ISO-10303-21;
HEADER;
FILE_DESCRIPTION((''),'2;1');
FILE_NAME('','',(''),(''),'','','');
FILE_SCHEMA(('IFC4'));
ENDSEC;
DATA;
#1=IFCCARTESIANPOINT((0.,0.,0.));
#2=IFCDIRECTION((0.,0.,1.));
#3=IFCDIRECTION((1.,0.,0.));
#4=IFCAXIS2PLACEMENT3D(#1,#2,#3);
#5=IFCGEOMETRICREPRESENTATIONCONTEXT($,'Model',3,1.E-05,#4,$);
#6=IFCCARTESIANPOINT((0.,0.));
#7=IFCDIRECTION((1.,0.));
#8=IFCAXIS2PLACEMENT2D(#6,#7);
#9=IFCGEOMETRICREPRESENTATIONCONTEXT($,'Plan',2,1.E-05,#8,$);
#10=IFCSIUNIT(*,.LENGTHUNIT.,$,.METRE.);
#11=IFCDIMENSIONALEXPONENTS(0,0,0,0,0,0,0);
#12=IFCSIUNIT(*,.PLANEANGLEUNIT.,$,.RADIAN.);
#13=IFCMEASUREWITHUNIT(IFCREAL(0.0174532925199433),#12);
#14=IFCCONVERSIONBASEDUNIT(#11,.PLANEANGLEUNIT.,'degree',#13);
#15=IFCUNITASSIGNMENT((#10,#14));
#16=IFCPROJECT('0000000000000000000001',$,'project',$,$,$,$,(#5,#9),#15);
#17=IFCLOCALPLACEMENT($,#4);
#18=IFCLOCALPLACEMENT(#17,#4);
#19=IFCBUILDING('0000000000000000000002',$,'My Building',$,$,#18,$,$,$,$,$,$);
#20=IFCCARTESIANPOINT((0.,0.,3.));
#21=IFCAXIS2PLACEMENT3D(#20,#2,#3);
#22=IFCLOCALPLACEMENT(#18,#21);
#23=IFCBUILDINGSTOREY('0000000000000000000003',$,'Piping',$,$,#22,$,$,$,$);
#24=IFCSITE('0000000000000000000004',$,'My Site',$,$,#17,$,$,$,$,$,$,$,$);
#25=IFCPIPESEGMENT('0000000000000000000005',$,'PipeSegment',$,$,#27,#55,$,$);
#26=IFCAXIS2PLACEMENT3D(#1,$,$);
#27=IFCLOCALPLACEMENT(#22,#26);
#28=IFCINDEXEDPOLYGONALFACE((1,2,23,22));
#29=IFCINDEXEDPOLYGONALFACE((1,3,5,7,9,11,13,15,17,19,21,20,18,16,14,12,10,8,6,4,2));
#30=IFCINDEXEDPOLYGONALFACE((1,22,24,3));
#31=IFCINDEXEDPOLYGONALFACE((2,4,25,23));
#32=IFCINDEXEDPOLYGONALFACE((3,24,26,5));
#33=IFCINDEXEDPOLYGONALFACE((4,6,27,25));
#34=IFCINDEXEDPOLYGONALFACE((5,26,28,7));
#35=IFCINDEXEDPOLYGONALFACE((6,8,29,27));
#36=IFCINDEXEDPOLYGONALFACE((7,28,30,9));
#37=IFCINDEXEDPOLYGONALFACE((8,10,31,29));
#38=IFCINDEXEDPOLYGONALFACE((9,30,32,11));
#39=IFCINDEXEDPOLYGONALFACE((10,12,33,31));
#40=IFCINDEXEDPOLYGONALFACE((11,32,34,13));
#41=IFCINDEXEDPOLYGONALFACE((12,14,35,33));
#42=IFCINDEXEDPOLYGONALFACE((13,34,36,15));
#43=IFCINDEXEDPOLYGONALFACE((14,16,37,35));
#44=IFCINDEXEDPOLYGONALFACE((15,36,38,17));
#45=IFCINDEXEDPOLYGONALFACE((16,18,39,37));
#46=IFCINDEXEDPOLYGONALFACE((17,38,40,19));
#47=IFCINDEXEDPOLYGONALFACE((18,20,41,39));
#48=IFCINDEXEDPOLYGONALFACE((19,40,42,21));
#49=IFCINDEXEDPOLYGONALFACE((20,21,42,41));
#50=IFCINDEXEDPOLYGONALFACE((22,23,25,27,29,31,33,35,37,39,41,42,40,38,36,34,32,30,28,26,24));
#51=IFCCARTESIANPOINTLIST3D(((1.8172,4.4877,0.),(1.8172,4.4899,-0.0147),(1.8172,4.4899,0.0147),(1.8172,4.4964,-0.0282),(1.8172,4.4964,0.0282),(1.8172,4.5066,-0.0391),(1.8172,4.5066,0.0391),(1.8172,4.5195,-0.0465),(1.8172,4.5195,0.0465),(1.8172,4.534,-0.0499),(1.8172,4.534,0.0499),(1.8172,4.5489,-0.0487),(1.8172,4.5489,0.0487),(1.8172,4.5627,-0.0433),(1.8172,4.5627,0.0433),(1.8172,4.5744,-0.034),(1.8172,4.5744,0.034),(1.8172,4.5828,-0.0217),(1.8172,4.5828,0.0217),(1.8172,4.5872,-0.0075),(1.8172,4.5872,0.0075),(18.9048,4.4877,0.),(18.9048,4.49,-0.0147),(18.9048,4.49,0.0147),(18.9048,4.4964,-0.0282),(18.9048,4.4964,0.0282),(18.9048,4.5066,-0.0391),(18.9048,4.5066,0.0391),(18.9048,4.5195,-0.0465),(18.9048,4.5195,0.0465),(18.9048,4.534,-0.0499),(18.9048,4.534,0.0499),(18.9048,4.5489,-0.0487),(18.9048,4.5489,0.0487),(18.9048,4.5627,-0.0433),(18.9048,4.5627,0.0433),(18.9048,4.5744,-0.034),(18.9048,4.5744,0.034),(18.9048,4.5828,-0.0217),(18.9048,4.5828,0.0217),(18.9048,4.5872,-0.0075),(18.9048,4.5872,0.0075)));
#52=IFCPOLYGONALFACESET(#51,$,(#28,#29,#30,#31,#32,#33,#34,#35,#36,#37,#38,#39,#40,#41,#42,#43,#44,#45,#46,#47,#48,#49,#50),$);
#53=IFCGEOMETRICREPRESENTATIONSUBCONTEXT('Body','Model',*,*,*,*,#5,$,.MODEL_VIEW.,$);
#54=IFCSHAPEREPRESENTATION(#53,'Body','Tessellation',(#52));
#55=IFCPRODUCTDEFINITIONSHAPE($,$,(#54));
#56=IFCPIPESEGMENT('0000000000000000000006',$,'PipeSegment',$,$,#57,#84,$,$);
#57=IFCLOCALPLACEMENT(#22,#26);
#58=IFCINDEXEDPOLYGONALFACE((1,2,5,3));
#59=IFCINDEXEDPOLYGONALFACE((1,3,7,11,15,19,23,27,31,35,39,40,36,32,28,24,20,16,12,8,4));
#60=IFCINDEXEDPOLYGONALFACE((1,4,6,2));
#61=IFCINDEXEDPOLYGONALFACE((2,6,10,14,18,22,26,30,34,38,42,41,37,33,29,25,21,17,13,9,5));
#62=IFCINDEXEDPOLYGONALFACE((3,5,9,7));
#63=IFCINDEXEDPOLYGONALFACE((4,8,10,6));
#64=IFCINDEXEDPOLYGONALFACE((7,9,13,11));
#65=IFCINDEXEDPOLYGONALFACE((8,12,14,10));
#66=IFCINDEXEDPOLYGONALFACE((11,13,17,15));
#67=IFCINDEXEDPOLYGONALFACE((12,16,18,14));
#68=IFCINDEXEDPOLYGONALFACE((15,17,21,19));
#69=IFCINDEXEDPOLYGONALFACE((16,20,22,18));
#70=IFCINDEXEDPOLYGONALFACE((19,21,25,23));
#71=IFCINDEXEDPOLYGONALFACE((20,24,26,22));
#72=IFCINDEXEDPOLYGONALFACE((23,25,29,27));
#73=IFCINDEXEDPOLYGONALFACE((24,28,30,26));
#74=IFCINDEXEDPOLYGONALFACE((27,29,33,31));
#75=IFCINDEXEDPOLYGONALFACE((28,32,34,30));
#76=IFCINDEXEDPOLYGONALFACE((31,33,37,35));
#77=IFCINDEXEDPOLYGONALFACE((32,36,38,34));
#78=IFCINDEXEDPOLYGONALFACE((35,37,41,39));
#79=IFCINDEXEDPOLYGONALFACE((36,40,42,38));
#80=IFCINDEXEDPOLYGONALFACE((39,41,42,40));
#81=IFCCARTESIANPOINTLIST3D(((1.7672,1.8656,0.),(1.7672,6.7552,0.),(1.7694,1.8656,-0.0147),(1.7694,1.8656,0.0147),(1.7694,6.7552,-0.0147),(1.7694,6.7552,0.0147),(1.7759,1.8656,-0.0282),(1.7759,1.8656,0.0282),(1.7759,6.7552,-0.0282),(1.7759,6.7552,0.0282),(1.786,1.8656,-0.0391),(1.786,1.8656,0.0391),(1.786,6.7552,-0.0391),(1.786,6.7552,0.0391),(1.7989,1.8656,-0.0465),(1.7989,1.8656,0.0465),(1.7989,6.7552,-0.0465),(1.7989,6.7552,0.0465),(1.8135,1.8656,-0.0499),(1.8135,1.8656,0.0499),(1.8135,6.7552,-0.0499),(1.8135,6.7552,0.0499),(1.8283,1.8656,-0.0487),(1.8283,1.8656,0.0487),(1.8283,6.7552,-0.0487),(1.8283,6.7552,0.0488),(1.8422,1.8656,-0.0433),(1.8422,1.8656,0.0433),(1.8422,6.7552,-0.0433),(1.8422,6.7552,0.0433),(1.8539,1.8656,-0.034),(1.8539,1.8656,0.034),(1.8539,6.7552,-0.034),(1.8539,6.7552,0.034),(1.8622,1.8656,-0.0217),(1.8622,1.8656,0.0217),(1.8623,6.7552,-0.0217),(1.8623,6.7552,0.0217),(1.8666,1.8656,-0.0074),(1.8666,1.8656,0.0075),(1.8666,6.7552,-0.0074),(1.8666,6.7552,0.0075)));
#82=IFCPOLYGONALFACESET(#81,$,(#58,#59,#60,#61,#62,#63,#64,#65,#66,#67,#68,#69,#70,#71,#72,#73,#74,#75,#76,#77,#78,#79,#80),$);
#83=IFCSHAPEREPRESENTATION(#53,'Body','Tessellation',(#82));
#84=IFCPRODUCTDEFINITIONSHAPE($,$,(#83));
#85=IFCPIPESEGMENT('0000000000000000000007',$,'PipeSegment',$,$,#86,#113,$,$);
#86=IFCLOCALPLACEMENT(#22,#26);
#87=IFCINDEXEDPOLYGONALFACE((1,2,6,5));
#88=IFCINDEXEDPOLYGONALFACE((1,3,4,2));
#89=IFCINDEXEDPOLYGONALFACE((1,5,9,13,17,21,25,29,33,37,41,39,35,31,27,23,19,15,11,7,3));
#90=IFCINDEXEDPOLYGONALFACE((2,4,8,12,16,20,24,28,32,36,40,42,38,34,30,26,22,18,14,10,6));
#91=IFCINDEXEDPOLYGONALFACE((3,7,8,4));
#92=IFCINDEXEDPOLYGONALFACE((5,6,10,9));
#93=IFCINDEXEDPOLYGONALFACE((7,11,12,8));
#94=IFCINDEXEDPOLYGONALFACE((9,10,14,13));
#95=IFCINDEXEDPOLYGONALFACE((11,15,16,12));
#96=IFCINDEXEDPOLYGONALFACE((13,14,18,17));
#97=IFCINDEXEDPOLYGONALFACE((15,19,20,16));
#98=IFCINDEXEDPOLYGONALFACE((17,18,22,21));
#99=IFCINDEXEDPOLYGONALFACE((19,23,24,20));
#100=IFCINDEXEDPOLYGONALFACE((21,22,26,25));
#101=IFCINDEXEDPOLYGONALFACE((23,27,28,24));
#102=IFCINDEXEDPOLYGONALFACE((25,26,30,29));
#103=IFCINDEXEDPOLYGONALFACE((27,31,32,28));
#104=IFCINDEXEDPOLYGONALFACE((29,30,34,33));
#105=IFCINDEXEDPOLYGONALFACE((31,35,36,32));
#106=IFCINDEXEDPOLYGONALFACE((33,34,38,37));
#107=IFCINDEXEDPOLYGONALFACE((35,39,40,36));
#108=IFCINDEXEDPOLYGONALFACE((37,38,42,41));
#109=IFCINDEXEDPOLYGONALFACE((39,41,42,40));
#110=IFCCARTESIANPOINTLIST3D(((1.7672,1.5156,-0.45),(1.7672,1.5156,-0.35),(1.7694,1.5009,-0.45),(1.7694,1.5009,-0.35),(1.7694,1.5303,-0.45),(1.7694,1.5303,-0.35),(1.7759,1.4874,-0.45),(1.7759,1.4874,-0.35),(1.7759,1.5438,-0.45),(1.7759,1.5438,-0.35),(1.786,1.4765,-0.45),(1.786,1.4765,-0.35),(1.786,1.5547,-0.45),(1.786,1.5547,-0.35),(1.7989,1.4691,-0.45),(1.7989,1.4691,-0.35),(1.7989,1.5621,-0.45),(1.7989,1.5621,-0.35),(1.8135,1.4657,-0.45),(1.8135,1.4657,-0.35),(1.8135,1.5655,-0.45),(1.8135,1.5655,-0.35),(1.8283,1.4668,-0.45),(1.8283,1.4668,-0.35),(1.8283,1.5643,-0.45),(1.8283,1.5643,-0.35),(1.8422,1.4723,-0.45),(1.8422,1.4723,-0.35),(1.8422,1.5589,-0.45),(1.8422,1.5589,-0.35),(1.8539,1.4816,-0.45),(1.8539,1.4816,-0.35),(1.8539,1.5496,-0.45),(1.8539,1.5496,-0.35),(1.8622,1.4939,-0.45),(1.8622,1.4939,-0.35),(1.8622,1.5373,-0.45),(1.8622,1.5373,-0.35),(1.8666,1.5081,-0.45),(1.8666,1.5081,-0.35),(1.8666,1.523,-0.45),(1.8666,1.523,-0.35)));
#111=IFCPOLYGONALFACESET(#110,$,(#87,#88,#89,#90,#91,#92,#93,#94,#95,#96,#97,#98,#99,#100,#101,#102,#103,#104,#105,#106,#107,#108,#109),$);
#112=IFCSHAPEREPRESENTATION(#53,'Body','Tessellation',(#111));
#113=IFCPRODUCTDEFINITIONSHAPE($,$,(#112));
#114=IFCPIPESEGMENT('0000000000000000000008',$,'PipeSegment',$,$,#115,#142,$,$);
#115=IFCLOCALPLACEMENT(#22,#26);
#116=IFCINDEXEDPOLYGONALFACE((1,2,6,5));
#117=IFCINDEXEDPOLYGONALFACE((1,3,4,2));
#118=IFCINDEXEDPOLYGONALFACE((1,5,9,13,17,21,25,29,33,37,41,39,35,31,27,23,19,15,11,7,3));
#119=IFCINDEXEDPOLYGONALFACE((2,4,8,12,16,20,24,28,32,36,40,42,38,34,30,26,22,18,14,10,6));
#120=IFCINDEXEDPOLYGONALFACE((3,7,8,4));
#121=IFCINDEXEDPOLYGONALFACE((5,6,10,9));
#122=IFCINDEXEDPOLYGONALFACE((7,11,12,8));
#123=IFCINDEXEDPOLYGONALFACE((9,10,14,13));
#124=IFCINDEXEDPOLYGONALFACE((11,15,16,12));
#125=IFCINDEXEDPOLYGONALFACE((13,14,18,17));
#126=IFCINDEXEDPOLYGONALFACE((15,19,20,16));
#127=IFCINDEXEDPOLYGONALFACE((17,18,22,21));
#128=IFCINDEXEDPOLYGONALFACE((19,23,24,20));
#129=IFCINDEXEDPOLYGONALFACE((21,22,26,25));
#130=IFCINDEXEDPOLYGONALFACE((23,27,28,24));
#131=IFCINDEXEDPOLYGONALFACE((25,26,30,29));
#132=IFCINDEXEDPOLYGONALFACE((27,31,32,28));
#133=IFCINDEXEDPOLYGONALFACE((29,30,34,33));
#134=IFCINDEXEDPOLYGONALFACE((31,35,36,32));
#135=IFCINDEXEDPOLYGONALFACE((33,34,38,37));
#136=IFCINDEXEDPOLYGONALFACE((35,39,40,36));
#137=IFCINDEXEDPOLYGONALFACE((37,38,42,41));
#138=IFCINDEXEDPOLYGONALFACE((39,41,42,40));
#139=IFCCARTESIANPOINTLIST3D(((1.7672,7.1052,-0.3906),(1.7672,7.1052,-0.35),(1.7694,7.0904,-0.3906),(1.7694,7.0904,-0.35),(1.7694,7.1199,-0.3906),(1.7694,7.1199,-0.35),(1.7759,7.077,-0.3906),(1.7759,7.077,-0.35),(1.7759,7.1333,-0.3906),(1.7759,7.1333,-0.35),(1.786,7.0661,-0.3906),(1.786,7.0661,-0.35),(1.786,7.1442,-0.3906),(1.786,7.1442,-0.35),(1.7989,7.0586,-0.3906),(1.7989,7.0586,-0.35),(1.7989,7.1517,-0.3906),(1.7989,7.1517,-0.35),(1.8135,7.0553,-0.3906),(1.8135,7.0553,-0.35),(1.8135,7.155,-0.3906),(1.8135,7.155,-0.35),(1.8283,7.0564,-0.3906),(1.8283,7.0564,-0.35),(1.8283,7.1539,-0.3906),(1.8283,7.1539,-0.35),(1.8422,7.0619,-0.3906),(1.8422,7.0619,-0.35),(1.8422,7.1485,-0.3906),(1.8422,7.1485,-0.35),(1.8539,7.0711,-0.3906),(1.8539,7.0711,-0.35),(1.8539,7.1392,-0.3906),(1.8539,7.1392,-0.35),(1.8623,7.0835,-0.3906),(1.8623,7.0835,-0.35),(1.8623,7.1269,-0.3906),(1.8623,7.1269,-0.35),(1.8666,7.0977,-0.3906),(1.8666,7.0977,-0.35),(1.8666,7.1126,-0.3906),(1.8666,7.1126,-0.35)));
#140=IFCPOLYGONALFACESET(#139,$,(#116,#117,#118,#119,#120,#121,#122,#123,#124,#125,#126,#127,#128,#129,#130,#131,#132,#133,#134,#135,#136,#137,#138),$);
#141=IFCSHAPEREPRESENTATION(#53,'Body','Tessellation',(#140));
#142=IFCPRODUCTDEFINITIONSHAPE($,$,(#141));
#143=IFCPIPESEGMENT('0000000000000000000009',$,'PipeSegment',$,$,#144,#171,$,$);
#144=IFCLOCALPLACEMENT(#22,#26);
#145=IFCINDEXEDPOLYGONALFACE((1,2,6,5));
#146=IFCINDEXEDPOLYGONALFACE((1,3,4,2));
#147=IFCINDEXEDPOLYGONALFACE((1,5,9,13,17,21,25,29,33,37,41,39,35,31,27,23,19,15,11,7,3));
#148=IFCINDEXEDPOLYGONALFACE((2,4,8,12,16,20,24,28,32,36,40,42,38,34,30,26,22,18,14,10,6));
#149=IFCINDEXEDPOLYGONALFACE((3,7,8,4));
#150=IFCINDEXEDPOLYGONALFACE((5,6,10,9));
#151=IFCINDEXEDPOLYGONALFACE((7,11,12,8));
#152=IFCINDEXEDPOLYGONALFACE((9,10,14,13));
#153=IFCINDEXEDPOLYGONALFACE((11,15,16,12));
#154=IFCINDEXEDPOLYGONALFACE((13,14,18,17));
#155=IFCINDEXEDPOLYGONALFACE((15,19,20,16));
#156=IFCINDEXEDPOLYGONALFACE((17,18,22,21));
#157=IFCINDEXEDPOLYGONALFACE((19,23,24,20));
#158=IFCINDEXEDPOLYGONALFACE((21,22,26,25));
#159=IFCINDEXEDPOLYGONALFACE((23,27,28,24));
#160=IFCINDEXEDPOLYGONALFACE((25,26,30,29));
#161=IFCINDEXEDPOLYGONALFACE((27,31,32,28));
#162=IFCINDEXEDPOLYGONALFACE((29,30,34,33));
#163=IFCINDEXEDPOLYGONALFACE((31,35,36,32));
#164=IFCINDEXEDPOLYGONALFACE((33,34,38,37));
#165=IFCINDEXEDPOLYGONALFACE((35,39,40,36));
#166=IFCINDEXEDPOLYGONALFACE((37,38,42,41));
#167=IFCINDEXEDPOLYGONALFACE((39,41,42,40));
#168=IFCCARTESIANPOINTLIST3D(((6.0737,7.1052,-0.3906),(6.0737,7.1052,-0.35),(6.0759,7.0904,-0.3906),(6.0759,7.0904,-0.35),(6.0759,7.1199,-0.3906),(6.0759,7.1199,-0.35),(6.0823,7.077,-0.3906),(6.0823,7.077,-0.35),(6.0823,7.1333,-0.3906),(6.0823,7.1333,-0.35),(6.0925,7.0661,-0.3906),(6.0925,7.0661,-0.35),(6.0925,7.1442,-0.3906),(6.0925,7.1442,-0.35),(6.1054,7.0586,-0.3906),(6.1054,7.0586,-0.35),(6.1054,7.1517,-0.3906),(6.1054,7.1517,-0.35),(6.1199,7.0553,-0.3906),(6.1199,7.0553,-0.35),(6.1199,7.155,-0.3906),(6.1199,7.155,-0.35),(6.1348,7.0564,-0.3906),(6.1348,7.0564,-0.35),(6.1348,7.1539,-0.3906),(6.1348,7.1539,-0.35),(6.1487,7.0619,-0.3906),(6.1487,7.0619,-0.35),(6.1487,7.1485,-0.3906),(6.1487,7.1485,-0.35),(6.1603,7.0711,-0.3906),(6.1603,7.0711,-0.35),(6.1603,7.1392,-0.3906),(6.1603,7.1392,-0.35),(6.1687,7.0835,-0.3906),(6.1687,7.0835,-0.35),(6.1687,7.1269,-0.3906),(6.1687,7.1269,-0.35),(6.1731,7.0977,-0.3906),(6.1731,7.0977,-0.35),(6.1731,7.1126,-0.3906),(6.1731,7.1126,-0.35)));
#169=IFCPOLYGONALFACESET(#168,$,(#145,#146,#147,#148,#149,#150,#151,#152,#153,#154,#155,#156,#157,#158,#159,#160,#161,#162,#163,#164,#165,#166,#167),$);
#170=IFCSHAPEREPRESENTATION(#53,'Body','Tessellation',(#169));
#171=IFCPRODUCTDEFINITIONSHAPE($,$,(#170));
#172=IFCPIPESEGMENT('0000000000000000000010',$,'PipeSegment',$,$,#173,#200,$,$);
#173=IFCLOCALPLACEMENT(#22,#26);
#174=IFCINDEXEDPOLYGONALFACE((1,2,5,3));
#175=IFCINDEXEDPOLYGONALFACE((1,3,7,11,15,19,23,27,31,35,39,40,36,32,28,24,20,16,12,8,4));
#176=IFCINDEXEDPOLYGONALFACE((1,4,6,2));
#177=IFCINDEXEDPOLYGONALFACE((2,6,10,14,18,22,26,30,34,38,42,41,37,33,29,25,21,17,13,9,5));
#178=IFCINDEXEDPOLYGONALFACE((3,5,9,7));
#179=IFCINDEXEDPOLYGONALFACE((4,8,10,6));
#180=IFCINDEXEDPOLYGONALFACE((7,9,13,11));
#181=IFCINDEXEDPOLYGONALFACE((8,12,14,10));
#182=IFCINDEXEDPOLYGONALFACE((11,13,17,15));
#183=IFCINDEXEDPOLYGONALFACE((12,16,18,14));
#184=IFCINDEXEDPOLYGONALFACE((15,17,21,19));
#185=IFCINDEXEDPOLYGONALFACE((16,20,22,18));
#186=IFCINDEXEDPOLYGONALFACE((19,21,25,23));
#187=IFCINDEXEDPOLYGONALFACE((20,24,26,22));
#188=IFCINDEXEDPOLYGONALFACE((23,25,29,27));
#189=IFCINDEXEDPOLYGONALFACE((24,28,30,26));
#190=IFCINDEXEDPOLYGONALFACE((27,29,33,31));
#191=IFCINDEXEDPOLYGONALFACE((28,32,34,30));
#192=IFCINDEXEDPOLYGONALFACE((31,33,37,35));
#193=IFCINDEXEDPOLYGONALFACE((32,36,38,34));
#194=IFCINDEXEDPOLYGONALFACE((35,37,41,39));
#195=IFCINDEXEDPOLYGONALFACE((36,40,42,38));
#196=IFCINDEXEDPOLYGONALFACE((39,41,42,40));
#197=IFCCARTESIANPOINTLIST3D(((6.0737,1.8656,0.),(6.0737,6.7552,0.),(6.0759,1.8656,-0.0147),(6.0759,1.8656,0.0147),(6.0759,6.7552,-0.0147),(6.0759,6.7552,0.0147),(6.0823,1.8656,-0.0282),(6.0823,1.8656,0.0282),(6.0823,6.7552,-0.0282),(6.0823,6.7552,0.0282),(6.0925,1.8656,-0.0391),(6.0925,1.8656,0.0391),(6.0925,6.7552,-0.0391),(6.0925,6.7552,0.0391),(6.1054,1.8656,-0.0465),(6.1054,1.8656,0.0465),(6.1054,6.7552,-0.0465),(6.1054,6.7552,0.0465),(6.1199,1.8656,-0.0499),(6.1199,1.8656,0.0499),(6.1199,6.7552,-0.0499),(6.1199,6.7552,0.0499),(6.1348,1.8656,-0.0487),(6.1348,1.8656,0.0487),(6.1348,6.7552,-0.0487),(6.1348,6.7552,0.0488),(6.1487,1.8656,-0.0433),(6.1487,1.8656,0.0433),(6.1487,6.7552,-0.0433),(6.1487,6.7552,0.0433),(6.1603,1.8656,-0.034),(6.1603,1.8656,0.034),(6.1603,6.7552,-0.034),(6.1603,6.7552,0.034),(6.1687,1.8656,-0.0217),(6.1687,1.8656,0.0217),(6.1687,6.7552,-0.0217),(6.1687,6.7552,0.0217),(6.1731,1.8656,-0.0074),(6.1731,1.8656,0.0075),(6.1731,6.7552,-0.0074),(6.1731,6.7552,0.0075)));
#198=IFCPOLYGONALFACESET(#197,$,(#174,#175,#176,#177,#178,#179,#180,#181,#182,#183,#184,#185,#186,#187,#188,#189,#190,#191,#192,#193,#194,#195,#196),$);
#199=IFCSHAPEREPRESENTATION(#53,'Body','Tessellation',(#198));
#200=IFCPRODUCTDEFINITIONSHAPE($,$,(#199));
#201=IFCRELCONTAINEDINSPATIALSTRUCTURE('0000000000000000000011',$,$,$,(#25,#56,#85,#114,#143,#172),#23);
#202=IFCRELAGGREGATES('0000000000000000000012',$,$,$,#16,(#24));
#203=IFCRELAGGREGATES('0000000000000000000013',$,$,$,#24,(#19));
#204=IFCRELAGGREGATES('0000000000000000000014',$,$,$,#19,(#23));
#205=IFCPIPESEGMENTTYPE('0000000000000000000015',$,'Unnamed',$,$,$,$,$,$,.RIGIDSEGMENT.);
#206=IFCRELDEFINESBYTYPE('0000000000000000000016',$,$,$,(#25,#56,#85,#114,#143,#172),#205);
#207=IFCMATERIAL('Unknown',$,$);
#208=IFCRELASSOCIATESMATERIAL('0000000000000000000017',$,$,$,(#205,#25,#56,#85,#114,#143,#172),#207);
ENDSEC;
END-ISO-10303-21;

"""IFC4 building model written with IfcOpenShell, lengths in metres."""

from ifc_helpers import new_model, entity, si_unit, converted_unit, frame, origin_with_axes, origin_2d_with_axis, place, context, subcontext, project, spatial, circle, extrude, material, material_profile, profile_set, profile_usage, type_object, element, save


model = new_model("IFC4")

# Units and contexts
model_context = context("Model", 3, precision=1e-05, world=origin_with_axes())
plan_context = context("Plan", 2, precision=1e-05, world=origin_2d_with_axis())
body_context = subcontext(model_context, "Body", "Model", "MODEL_VIEW")
ifc_project = project(units=[si_unit("LENGTHUNIT", "METRE"), converted_unit("PLANEANGLEUNIT", "degree", entity("IfcReal", 0.0174532925199433), si_unit("PLANEANGLEUNIT", "RADIAN"), dimensions=[0, 0, 0, 0, 0, 0, 0])], contexts=[model_context, plan_context])

# Site, building, storey
site_placement = place(None, origin_with_axes())
site = spatial("IfcSite", under=ifc_project, at=site_placement, Name="My Site")
building_placement = place(site_placement, origin_with_axes())
building = spatial("IfcBuilding", under=site, at=building_placement, Name="My Building")
storey_placement = place(building_placement, frame((0.0, 0.0, 3.0), z_axis=(0.0, 0.0, 1.0), x_axis=(1.0, 0.0, 0.0)))
storey = spatial("IfcBuildingStorey", under=building, at=storey_placement, Name="Piping")

# Pipe segments
ifc_material = material(Name="Unknown")
ifc_material_profile = material_profile(ifc_material, circle(Radius=0.05))
ifc_profile_set = profile_set([ifc_material_profile])
ifc_profile_usage_1 = profile_usage(ifc_profile_set, cardinal=5)
pipe_segment_type = type_object("IfcPipeSegmentType", Name="Unnamed", PredefinedType="RIGIDSEGMENT", material=ifc_profile_set)
pipe_segment_1_placement = place(storey_placement, frame((18.9048, 4.5377, 0.0), z_axis=(-1.0, 0.0, 0.0), x_axis=(0.0, -1.0, 0.0)))
element("IfcPipeSegment", 1, at=pipe_segment_1_placement, inside=storey, type_object=pipe_segment_type, material=ifc_profile_usage_1, Name="PipeSegment", context=body_context, shape_type="SweptSolid", body=[
    extrude(circle(Radius=0.05), origin_with_axes(), (0.0, 0.0, 1.0), 17.0876),
])
ifc_profile_usage_2 = profile_usage(ifc_profile_set, cardinal=5)
pipe_segment_2_placement = place(storey_placement, frame((1.8172, 1.8656, 0.0), z_axis=(0.0, 1.0, 0.0), x_axis=(-1.0, 0.0, 0.0)))
element("IfcPipeSegment", 2, at=pipe_segment_2_placement, inside=storey, type_object=pipe_segment_type, material=ifc_profile_usage_2, Name="PipeSegment", context=body_context, shape_type="SweptSolid", body=[
    extrude(circle(Radius=0.05), origin_with_axes(), (0.0, 0.0, 1.0), 4.8896),
])
ifc_profile_usage_3 = profile_usage(ifc_profile_set, cardinal=5)
pipe_segment_3_placement = place(storey_placement, frame((1.8172, 1.5156, -0.35), z_axis=(0.0, 0.0, -1.0), x_axis=(-1.0, 0.0, 0.0)))
element("IfcPipeSegment", 3, at=pipe_segment_3_placement, inside=storey, type_object=pipe_segment_type, material=ifc_profile_usage_3, Name="PipeSegment", context=body_context, shape_type="SweptSolid", body=[
    extrude(circle(Radius=0.05), origin_with_axes(), (0.0, 0.0, 1.0), 0.1),
])
ifc_profile_usage_4 = profile_usage(ifc_profile_set, cardinal=5)
pipe_segment_4_placement = place(storey_placement, frame((1.8172, 7.1052, -0.35), z_axis=(0.0, 0.0, -1.0), x_axis=(-1.0, 0.0, 0.0)))
element("IfcPipeSegment", 4, at=pipe_segment_4_placement, inside=storey, type_object=pipe_segment_type, material=ifc_profile_usage_4, Name="PipeSegment", context=body_context, shape_type="SweptSolid", body=[
    extrude(circle(Radius=0.05), origin_with_axes(), (0.0, 0.0, 1.0), 0.0406),
])
ifc_profile_usage_5 = profile_usage(ifc_profile_set, cardinal=5)
pipe_segment_5_placement = place(storey_placement, frame((6.1237, 7.1052, -0.35), z_axis=(0.0, 0.0, -1.0), x_axis=(-1.0, 0.0, 0.0)))
element("IfcPipeSegment", 5, at=pipe_segment_5_placement, inside=storey, type_object=pipe_segment_type, material=ifc_profile_usage_5, Name="PipeSegment", context=body_context, shape_type="SweptSolid", body=[
    extrude(circle(Radius=0.05), origin_with_axes(), (0.0, 0.0, 1.0), 0.0406),
])
ifc_profile_usage_6 = profile_usage(ifc_profile_set, cardinal=5)
pipe_segment_6_placement = place(storey_placement, frame((6.1237, 1.8656, 0.0), z_axis=(0.0, 1.0, 0.0), x_axis=(-1.0, 0.0, 0.0)))
element("IfcPipeSegment", 6, at=pipe_segment_6_placement, inside=storey, type_object=pipe_segment_type, material=ifc_profile_usage_6, Name="PipeSegment", context=body_context, shape_type="SweptSolid", body=[
    extrude(circle(Radius=0.05), origin_with_axes(), (0.0, 0.0, 1.0), 4.8896),
])

save(model, "model.ifc")
